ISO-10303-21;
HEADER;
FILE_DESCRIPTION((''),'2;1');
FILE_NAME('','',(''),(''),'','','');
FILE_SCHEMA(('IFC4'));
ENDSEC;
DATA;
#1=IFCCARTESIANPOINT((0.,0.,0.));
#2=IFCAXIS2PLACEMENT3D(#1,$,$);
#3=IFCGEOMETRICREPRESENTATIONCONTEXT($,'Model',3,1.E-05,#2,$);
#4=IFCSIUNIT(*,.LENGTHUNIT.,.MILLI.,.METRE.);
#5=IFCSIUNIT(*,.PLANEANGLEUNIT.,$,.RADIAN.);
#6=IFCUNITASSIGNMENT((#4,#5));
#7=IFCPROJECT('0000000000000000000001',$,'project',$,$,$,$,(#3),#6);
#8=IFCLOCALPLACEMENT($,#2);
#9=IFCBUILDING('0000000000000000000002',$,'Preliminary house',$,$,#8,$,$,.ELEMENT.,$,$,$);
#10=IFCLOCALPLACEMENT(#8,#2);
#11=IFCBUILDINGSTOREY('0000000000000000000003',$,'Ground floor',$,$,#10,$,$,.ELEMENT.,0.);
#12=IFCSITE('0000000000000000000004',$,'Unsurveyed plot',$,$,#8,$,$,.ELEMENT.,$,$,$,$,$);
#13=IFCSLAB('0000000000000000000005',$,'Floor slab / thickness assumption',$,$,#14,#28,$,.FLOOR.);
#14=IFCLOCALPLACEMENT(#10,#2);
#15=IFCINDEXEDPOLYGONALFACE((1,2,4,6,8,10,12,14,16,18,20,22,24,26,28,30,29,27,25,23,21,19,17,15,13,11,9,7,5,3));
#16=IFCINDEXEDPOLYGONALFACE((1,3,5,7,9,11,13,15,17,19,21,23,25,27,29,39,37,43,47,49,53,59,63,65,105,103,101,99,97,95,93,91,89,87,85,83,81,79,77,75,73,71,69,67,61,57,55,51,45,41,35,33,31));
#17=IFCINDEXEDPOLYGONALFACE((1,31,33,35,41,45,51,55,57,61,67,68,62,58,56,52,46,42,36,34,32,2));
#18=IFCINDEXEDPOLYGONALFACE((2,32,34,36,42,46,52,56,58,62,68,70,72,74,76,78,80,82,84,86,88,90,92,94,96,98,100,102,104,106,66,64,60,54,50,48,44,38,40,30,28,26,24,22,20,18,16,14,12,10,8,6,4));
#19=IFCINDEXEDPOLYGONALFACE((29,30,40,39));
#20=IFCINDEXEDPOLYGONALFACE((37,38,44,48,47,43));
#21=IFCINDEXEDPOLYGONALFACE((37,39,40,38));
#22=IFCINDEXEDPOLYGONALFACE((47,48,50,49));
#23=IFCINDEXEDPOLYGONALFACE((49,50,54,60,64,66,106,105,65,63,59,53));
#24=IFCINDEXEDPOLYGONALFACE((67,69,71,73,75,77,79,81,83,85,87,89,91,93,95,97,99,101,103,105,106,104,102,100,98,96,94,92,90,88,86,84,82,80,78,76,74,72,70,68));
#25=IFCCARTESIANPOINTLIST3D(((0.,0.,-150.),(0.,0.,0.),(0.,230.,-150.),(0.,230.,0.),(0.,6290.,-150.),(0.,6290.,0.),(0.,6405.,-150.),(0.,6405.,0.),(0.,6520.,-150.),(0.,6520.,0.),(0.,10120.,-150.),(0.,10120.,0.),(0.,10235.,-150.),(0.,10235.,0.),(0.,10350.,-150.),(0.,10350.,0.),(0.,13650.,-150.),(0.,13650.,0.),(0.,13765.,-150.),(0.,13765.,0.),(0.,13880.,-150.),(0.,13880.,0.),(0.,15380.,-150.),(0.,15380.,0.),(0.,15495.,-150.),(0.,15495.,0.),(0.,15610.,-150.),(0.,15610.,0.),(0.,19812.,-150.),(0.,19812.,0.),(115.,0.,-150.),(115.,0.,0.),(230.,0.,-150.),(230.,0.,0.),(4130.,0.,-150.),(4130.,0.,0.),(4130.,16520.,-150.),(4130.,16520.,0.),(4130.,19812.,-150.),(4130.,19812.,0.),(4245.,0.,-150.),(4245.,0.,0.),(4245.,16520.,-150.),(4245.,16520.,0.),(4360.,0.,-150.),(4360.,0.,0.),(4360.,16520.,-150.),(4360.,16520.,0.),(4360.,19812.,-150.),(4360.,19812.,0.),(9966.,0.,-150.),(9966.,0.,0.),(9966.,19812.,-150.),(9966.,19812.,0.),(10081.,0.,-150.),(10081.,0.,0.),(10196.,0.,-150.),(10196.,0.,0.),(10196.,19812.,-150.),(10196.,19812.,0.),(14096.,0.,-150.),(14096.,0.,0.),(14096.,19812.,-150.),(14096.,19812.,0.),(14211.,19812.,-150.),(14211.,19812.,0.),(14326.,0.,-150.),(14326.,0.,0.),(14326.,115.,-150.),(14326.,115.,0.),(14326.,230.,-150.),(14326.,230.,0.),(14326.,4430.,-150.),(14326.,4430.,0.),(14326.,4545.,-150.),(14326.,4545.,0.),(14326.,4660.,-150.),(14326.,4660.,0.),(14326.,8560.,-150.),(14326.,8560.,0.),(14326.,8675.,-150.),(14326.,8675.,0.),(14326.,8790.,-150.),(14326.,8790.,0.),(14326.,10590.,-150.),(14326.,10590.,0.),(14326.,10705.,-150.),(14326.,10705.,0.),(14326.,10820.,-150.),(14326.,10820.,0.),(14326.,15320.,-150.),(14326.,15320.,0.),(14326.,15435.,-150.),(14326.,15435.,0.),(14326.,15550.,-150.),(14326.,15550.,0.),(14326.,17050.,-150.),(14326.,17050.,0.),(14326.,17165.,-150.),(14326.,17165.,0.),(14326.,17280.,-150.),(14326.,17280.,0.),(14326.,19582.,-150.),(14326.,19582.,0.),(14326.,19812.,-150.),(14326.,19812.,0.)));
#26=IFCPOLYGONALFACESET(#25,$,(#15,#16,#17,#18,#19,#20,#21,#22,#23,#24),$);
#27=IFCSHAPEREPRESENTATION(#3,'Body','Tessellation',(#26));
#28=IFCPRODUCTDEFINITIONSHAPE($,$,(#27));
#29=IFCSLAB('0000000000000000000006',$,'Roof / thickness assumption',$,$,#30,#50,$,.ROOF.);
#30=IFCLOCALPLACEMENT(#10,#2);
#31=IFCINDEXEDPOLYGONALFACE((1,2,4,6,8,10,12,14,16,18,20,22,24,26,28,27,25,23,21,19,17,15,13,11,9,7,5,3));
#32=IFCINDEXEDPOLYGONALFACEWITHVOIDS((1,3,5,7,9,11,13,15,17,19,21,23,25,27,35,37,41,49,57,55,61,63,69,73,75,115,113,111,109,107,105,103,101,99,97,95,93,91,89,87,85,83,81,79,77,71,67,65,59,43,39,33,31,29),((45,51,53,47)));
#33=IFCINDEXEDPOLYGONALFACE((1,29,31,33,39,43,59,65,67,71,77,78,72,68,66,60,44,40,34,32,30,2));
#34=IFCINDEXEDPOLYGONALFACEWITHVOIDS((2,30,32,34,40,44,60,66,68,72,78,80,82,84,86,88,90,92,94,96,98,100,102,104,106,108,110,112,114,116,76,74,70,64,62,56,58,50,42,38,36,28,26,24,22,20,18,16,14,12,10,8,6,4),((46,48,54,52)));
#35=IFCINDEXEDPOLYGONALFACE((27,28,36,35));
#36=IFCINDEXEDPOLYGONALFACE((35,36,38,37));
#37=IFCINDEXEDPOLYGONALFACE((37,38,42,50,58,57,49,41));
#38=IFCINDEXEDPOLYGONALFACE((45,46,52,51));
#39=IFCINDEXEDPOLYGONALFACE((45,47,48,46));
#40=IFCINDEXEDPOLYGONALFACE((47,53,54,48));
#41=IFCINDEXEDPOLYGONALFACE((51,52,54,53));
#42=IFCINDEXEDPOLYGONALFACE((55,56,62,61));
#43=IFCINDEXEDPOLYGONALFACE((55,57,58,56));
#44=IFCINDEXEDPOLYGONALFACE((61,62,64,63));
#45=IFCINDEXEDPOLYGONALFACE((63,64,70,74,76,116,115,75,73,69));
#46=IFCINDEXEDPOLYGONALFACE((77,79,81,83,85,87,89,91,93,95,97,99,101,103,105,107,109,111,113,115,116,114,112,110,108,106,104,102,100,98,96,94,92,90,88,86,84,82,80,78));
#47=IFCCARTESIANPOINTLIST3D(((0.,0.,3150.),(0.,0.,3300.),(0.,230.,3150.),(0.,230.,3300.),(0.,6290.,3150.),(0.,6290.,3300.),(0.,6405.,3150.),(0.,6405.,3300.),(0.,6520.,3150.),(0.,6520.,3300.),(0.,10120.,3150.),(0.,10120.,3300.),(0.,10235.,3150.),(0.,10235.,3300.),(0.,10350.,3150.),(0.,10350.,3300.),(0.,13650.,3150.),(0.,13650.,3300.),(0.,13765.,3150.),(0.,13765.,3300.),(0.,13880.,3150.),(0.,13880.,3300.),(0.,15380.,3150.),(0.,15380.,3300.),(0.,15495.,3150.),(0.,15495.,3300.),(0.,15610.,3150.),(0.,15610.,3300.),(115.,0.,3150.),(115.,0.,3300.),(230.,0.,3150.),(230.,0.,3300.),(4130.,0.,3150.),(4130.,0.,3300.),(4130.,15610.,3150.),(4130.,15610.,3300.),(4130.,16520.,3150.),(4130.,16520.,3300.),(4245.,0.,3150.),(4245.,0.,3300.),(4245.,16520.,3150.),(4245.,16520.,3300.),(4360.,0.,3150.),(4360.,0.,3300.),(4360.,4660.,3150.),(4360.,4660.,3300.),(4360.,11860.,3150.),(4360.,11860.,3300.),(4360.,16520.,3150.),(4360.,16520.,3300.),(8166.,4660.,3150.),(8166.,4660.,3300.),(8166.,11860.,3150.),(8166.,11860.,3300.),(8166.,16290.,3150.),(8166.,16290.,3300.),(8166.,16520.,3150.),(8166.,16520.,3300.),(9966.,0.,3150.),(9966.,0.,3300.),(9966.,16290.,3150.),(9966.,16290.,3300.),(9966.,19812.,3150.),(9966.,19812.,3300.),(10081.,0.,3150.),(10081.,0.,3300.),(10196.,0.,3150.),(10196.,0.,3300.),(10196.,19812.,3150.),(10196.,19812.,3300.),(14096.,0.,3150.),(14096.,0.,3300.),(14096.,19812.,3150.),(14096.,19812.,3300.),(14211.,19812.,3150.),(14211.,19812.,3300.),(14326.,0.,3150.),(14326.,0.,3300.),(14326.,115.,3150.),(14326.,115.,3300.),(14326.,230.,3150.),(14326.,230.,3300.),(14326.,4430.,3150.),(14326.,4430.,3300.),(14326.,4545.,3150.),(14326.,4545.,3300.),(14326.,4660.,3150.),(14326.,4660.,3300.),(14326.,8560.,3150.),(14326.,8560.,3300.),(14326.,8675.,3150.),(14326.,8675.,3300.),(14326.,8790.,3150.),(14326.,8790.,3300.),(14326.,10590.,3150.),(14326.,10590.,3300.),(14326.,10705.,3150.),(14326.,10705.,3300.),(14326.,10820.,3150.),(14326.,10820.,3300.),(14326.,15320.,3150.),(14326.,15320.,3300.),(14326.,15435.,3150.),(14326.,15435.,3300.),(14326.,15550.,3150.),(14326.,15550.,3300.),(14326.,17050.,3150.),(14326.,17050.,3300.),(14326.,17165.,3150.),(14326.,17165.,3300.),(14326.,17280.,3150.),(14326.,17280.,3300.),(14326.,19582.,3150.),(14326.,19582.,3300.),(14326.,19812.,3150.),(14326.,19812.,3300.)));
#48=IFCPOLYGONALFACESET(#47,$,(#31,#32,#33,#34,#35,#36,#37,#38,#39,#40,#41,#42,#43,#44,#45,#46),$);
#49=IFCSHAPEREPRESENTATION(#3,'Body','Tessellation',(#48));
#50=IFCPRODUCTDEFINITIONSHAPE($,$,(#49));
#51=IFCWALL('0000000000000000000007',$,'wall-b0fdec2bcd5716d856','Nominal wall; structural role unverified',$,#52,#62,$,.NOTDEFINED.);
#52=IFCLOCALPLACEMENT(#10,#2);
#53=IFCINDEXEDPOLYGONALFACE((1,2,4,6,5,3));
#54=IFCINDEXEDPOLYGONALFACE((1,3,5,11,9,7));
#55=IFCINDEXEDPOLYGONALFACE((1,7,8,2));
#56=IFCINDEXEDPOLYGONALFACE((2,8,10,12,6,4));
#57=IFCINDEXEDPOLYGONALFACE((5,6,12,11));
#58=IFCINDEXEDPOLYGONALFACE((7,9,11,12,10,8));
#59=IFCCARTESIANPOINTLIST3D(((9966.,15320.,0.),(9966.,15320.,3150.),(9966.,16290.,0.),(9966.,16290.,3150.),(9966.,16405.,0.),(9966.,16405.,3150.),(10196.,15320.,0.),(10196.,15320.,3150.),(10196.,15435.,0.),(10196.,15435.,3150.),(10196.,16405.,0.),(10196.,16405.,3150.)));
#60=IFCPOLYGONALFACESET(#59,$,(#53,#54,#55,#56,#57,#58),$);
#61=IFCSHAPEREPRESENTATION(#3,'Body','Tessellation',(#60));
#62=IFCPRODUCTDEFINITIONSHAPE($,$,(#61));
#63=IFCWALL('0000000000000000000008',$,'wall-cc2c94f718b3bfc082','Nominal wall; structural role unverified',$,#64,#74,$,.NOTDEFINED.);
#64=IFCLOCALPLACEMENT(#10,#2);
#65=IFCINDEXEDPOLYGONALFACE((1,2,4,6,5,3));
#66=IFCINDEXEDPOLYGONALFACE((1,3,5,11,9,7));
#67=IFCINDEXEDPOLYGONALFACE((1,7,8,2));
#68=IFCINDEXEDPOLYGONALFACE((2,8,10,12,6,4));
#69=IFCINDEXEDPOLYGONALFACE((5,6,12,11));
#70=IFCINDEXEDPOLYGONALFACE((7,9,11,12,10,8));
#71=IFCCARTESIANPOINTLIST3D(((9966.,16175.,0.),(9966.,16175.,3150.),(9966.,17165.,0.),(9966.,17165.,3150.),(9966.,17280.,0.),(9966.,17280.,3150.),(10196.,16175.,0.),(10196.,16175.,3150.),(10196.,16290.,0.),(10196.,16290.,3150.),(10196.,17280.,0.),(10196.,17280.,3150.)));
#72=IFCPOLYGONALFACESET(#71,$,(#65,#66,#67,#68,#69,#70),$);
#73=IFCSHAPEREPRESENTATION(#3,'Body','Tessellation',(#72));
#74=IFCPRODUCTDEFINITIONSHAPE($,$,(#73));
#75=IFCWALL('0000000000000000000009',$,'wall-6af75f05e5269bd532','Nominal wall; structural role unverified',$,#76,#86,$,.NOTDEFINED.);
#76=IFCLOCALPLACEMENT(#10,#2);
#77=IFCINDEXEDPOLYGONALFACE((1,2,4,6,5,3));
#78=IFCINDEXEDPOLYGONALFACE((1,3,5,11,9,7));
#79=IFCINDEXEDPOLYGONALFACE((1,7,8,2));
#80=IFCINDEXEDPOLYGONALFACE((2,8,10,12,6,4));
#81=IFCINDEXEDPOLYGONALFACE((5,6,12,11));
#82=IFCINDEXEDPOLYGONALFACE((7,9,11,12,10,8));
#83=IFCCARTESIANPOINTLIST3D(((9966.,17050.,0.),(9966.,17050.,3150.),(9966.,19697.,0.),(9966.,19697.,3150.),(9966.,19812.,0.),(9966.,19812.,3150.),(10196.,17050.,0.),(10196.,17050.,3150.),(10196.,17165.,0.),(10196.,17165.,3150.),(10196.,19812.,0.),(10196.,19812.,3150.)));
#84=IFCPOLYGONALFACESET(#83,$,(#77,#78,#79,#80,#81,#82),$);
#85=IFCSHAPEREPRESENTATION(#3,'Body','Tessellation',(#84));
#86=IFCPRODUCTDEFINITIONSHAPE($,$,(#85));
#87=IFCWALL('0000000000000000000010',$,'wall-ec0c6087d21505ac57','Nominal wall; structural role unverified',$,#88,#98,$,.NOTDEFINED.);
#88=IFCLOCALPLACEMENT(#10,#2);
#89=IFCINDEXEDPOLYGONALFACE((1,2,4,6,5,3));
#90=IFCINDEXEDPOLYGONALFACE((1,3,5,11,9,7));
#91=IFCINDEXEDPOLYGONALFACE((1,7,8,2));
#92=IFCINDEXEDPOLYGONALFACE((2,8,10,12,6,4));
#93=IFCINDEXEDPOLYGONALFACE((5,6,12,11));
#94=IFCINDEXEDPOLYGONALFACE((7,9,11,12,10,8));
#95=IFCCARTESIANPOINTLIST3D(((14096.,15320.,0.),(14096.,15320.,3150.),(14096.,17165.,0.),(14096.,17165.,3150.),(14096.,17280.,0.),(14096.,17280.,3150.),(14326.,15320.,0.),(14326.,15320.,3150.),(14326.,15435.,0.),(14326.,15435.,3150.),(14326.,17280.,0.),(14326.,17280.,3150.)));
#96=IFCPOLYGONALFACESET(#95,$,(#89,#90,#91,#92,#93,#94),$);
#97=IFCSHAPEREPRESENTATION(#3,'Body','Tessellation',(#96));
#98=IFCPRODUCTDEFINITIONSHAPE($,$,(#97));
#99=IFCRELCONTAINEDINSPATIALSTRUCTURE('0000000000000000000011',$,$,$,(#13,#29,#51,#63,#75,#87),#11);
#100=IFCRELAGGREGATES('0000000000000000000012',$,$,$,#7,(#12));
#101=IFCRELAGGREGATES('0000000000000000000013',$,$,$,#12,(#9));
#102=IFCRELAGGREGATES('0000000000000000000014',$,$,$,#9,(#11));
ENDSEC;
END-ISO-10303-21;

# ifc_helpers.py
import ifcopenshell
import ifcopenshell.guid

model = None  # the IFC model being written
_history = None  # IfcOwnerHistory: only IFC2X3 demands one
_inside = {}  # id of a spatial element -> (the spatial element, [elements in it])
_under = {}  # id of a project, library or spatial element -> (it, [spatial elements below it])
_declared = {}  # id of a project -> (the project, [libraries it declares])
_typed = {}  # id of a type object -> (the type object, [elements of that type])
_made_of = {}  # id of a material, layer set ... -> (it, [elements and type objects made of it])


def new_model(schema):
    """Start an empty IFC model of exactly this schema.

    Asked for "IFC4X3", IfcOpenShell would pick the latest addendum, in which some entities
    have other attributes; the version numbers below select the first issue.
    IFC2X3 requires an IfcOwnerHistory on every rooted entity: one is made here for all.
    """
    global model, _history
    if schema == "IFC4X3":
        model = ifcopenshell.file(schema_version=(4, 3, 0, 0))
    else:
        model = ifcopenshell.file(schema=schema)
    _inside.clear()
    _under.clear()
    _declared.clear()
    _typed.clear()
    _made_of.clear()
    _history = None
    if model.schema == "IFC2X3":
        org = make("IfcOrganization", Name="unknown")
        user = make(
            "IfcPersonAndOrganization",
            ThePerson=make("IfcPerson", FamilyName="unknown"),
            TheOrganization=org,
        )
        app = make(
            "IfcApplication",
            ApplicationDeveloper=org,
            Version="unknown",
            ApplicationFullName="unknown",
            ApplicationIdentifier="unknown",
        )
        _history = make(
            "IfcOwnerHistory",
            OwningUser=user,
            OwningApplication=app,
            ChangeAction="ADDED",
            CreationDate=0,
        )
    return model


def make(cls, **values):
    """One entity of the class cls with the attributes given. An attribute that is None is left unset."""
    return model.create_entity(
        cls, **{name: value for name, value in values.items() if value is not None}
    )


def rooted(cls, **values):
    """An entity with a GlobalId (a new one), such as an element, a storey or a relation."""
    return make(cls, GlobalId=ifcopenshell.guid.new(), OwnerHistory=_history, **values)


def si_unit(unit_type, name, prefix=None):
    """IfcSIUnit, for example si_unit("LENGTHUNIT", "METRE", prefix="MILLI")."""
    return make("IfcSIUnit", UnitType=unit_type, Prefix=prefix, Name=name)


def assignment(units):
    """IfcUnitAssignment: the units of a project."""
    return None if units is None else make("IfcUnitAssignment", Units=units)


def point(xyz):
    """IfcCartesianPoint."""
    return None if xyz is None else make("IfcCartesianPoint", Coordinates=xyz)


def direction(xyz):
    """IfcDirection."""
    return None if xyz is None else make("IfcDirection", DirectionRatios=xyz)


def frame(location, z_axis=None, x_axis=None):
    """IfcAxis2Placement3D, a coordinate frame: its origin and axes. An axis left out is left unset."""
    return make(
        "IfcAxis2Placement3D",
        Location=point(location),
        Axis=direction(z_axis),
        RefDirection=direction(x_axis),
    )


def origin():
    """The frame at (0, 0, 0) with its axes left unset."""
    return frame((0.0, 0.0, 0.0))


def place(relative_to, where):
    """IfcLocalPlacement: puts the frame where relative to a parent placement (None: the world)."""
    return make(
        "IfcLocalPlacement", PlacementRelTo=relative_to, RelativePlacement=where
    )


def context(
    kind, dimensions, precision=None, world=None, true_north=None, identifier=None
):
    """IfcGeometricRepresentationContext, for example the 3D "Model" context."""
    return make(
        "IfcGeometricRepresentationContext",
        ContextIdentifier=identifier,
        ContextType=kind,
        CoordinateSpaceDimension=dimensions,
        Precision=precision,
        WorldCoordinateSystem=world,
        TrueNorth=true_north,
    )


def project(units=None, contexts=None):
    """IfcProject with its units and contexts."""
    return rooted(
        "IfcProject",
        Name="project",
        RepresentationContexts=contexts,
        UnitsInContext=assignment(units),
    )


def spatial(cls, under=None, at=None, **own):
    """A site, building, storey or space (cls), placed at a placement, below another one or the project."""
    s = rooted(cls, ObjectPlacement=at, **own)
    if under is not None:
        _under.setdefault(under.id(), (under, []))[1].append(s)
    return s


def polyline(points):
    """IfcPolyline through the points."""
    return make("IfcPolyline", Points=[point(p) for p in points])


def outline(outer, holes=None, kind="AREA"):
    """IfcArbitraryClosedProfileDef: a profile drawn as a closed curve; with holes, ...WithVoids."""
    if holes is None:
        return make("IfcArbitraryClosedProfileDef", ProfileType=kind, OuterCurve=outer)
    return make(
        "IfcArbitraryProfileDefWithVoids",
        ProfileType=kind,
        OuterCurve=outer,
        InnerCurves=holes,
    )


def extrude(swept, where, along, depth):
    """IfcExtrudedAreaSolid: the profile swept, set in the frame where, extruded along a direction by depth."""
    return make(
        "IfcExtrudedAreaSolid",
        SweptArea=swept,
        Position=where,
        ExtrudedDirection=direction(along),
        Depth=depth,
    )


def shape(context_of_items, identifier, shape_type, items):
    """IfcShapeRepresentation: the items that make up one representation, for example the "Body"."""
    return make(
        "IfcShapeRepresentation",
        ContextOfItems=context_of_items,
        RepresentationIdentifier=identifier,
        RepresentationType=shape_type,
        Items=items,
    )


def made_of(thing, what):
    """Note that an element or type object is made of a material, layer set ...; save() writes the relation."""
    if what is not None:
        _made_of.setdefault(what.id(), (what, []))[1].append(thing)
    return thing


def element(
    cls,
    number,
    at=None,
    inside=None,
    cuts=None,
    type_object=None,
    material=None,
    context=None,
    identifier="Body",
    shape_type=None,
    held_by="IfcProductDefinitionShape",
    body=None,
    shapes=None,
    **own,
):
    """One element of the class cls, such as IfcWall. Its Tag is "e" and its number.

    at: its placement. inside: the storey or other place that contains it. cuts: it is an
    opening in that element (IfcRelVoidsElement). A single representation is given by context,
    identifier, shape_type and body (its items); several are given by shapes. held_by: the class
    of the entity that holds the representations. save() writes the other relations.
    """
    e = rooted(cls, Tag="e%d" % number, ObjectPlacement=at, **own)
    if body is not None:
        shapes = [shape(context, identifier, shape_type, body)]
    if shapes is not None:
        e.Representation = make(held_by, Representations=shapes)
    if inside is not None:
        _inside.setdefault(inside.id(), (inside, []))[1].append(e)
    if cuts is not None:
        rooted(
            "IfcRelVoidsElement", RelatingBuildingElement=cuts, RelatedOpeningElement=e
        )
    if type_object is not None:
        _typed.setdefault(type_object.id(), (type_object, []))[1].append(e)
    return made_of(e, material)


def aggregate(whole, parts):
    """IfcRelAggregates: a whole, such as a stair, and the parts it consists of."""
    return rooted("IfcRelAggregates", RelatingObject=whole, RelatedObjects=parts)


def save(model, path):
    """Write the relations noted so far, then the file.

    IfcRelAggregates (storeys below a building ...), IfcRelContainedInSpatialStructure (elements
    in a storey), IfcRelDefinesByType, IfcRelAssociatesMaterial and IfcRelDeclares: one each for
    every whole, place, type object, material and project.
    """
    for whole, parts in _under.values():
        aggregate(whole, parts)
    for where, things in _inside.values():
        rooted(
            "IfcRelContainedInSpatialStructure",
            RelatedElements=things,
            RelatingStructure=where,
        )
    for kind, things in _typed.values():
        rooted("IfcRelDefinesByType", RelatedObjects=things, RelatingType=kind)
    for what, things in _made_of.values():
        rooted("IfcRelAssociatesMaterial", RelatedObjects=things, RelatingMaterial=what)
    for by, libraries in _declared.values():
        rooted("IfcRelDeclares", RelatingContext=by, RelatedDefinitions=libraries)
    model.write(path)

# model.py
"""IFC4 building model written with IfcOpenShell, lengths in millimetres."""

from ifc_helpers import new_model, si_unit, frame, origin, place, context, project, spatial, polyline, outline, extrude, element, save


model = new_model("IFC4")

# Units and contexts
model_context = context("Model", 3, precision=1e-05, world=origin())
ifc_project = project(units=[si_unit("LENGTHUNIT", "METRE", prefix="MILLI"), si_unit("PLANEANGLEUNIT", "RADIAN")], contexts=[model_context])

# Site, building, storey
placement_1 = place(None, origin())
site = spatial("IfcSite", under=ifc_project, at=placement_1, Name="Unsurveyed plot", CompositionType="ELEMENT")
building = spatial("IfcBuilding", under=site, at=placement_1, Name="Preliminary house", CompositionType="ELEMENT")
placement_2 = place(placement_1, origin())
storey = spatial("IfcBuildingStorey", under=building, at=placement_2, Name="Ground floor", CompositionType="ELEMENT", Elevation=0.0)

# Slabs
element("IfcSlab", 1, at=placement_2, inside=storey, Name="Floor slab / thickness assumption", PredefinedType="FLOOR", context=model_context, shape_type="SweptSolid", body=[
    extrude(outline(polyline([(0.0, 0.0), (0.0, 230.0), (0.0, 6290.0), (0.0, 6405.0), (0.0, 6520.0), (0.0, 10120.0), (0.0, 10235.0), (0.0, 10350.0), (0.0, 13650.0), (0.0, 13765.0), (0.0, 13880.0), (0.0, 15380.0), (0.0, 15495.0), (0.0, 15610.0), (0.0, 19812.0), (4130.0, 19812.0), (4130.0, 16520.0), (4245.0, 16520.0), (4360.0, 16520.0), (4360.0, 19812.0), (9966.0, 19812.0), (10196.0, 19812.0), (14096.0, 19812.0), (14211.0, 19812.0), (14326.0, 19812.0), (14326.0, 19582.0), (14326.0, 17280.0), (14326.0, 17165.0), (14326.0, 17050.0), (14326.0, 15550.0), (14326.0, 15435.0), (14326.0, 15320.0), (14326.0, 10820.0), (14326.0, 10705.0), (14326.0, 10590.0), (14326.0, 8790.0), (14326.0, 8675.0), (14326.0, 8560.0), (14326.0, 4660.0), (14326.0, 4545.0), (14326.0, 4430.0), (14326.0, 230.0), (14326.0, 115.0), (14326.0, 0.0), (14096.0, 0.0), (10196.0, 0.0), (10081.0, 0.0), (9966.0, 0.0), (4360.0, 0.0), (4245.0, 0.0), (4130.0, 0.0), (230.0, 0.0), (115.0, 0.0), (0.0, 0.0)])), frame((0.0, 0.0, -150.0)), (0.0, 0.0, 1.0), 150.0),
])
element("IfcSlab", 2, at=placement_2, inside=storey, Name="Roof / thickness assumption", PredefinedType="ROOF", context=model_context, shape_type="SweptSolid", body=[
    extrude(outline(polyline([(0.0, 6405.0), (0.0, 6520.0), (0.0, 10120.0), (0.0, 10235.0), (0.0, 10350.0), (0.0, 13650.0), (0.0, 13765.0), (0.0, 13880.0), (0.0, 15380.0), (0.0, 15495.0), (0.0, 15610.0), (4130.0, 15610.0), (4130.0, 16520.0), (4245.0, 16520.0), (4360.0, 16520.0), (8166.0, 16520.0), (8166.0, 16290.0), (9966.0, 16290.0), (9966.0, 19812.0), (10196.0, 19812.0), (14096.0, 19812.0), (14211.0, 19812.0), (14326.0, 19812.0), (14326.0, 19582.0), (14326.0, 17280.0), (14326.0, 17165.0), (14326.0, 17050.0), (14326.0, 15550.0), (14326.0, 15435.0), (14326.0, 15320.0), (14326.0, 10820.0), (14326.0, 10705.0), (14326.0, 10590.0), (14326.0, 8790.0), (14326.0, 8675.0), (14326.0, 8560.0), (14326.0, 4660.0), (14326.0, 4545.0), (14326.0, 4430.0), (14326.0, 230.0), (14326.0, 115.0), (14326.0, 0.0), (14096.0, 0.0), (10196.0, 0.0), (10081.0, 0.0), (9966.0, 0.0), (4360.0, 0.0), (4245.0, 0.0), (4130.0, 0.0), (230.0, 0.0), (115.0, 0.0), (0.0, 0.0), (0.0, 230.0), (0.0, 6290.0), (0.0, 6405.0)]), holes=[polyline([(4360.0, 11860.0), (4360.0, 4660.0), (8166.0, 4660.0), (8166.0, 11860.0), (4360.0, 11860.0)])]), frame((0.0, 0.0, 3150.0)), (0.0, 0.0, 1.0), 150.0),
])

# Walls
element("IfcWall", 3, at=placement_2, inside=storey, Name="wall-b0fdec2bcd5716d856", Description="Nominal wall; structural role unverified", PredefinedType="NOTDEFINED", context=model_context, shape_type="SweptSolid", body=[
    extrude(outline(polyline([(9966.0, 16290.0), (9966.0, 16405.0), (10196.0, 16405.0), (10196.0, 15435.0), (10196.0, 15320.0), (9966.0, 15320.0), (9966.0, 16290.0)])), origin(), (0.0, 0.0, 1.0), 3150.0),
])
element("IfcWall", 4, at=placement_2, inside=storey, Name="wall-cc2c94f718b3bfc082", Description="Nominal wall; structural role unverified", PredefinedType="NOTDEFINED", context=model_context, shape_type="SweptSolid", body=[
    extrude(outline(polyline([(9966.0, 17165.0), (9966.0, 17280.0), (10196.0, 17280.0), (10196.0, 16290.0), (10196.0, 16175.0), (9966.0, 16175.0), (9966.0, 17165.0)])), origin(), (0.0, 0.0, 1.0), 3150.0),
])

# Wall
element("IfcWall", 5, at=placement_2, inside=storey, Name="wall-6af75f05e5269bd532", Description="Nominal wall; structural role unverified", PredefinedType="NOTDEFINED", context=model_context, shape_type="SweptSolid", body=[
    extrude(outline(polyline([(9966.0, 19697.0), (9966.0, 19812.0), (10196.0, 19812.0), (10196.0, 17165.0), (10196.0, 17050.0), (9966.0, 17050.0), (9966.0, 19697.0)])), origin(), (0.0, 0.0, 1.0), 3150.0),
])

# Wall
element("IfcWall", 6, at=placement_2, inside=storey, Name="wall-ec0c6087d21505ac57", Description="Nominal wall; structural role unverified", PredefinedType="NOTDEFINED", context=model_context, shape_type="SweptSolid", body=[
    extrude(outline(polyline([(14096.0, 17165.0), (14096.0, 17280.0), (14326.0, 17280.0), (14326.0, 15435.0), (14326.0, 15320.0), (14096.0, 15320.0), (14096.0, 17165.0)])), origin(), (0.0, 0.0, 1.0), 3150.0),
])

save(model, "model.ifc")
